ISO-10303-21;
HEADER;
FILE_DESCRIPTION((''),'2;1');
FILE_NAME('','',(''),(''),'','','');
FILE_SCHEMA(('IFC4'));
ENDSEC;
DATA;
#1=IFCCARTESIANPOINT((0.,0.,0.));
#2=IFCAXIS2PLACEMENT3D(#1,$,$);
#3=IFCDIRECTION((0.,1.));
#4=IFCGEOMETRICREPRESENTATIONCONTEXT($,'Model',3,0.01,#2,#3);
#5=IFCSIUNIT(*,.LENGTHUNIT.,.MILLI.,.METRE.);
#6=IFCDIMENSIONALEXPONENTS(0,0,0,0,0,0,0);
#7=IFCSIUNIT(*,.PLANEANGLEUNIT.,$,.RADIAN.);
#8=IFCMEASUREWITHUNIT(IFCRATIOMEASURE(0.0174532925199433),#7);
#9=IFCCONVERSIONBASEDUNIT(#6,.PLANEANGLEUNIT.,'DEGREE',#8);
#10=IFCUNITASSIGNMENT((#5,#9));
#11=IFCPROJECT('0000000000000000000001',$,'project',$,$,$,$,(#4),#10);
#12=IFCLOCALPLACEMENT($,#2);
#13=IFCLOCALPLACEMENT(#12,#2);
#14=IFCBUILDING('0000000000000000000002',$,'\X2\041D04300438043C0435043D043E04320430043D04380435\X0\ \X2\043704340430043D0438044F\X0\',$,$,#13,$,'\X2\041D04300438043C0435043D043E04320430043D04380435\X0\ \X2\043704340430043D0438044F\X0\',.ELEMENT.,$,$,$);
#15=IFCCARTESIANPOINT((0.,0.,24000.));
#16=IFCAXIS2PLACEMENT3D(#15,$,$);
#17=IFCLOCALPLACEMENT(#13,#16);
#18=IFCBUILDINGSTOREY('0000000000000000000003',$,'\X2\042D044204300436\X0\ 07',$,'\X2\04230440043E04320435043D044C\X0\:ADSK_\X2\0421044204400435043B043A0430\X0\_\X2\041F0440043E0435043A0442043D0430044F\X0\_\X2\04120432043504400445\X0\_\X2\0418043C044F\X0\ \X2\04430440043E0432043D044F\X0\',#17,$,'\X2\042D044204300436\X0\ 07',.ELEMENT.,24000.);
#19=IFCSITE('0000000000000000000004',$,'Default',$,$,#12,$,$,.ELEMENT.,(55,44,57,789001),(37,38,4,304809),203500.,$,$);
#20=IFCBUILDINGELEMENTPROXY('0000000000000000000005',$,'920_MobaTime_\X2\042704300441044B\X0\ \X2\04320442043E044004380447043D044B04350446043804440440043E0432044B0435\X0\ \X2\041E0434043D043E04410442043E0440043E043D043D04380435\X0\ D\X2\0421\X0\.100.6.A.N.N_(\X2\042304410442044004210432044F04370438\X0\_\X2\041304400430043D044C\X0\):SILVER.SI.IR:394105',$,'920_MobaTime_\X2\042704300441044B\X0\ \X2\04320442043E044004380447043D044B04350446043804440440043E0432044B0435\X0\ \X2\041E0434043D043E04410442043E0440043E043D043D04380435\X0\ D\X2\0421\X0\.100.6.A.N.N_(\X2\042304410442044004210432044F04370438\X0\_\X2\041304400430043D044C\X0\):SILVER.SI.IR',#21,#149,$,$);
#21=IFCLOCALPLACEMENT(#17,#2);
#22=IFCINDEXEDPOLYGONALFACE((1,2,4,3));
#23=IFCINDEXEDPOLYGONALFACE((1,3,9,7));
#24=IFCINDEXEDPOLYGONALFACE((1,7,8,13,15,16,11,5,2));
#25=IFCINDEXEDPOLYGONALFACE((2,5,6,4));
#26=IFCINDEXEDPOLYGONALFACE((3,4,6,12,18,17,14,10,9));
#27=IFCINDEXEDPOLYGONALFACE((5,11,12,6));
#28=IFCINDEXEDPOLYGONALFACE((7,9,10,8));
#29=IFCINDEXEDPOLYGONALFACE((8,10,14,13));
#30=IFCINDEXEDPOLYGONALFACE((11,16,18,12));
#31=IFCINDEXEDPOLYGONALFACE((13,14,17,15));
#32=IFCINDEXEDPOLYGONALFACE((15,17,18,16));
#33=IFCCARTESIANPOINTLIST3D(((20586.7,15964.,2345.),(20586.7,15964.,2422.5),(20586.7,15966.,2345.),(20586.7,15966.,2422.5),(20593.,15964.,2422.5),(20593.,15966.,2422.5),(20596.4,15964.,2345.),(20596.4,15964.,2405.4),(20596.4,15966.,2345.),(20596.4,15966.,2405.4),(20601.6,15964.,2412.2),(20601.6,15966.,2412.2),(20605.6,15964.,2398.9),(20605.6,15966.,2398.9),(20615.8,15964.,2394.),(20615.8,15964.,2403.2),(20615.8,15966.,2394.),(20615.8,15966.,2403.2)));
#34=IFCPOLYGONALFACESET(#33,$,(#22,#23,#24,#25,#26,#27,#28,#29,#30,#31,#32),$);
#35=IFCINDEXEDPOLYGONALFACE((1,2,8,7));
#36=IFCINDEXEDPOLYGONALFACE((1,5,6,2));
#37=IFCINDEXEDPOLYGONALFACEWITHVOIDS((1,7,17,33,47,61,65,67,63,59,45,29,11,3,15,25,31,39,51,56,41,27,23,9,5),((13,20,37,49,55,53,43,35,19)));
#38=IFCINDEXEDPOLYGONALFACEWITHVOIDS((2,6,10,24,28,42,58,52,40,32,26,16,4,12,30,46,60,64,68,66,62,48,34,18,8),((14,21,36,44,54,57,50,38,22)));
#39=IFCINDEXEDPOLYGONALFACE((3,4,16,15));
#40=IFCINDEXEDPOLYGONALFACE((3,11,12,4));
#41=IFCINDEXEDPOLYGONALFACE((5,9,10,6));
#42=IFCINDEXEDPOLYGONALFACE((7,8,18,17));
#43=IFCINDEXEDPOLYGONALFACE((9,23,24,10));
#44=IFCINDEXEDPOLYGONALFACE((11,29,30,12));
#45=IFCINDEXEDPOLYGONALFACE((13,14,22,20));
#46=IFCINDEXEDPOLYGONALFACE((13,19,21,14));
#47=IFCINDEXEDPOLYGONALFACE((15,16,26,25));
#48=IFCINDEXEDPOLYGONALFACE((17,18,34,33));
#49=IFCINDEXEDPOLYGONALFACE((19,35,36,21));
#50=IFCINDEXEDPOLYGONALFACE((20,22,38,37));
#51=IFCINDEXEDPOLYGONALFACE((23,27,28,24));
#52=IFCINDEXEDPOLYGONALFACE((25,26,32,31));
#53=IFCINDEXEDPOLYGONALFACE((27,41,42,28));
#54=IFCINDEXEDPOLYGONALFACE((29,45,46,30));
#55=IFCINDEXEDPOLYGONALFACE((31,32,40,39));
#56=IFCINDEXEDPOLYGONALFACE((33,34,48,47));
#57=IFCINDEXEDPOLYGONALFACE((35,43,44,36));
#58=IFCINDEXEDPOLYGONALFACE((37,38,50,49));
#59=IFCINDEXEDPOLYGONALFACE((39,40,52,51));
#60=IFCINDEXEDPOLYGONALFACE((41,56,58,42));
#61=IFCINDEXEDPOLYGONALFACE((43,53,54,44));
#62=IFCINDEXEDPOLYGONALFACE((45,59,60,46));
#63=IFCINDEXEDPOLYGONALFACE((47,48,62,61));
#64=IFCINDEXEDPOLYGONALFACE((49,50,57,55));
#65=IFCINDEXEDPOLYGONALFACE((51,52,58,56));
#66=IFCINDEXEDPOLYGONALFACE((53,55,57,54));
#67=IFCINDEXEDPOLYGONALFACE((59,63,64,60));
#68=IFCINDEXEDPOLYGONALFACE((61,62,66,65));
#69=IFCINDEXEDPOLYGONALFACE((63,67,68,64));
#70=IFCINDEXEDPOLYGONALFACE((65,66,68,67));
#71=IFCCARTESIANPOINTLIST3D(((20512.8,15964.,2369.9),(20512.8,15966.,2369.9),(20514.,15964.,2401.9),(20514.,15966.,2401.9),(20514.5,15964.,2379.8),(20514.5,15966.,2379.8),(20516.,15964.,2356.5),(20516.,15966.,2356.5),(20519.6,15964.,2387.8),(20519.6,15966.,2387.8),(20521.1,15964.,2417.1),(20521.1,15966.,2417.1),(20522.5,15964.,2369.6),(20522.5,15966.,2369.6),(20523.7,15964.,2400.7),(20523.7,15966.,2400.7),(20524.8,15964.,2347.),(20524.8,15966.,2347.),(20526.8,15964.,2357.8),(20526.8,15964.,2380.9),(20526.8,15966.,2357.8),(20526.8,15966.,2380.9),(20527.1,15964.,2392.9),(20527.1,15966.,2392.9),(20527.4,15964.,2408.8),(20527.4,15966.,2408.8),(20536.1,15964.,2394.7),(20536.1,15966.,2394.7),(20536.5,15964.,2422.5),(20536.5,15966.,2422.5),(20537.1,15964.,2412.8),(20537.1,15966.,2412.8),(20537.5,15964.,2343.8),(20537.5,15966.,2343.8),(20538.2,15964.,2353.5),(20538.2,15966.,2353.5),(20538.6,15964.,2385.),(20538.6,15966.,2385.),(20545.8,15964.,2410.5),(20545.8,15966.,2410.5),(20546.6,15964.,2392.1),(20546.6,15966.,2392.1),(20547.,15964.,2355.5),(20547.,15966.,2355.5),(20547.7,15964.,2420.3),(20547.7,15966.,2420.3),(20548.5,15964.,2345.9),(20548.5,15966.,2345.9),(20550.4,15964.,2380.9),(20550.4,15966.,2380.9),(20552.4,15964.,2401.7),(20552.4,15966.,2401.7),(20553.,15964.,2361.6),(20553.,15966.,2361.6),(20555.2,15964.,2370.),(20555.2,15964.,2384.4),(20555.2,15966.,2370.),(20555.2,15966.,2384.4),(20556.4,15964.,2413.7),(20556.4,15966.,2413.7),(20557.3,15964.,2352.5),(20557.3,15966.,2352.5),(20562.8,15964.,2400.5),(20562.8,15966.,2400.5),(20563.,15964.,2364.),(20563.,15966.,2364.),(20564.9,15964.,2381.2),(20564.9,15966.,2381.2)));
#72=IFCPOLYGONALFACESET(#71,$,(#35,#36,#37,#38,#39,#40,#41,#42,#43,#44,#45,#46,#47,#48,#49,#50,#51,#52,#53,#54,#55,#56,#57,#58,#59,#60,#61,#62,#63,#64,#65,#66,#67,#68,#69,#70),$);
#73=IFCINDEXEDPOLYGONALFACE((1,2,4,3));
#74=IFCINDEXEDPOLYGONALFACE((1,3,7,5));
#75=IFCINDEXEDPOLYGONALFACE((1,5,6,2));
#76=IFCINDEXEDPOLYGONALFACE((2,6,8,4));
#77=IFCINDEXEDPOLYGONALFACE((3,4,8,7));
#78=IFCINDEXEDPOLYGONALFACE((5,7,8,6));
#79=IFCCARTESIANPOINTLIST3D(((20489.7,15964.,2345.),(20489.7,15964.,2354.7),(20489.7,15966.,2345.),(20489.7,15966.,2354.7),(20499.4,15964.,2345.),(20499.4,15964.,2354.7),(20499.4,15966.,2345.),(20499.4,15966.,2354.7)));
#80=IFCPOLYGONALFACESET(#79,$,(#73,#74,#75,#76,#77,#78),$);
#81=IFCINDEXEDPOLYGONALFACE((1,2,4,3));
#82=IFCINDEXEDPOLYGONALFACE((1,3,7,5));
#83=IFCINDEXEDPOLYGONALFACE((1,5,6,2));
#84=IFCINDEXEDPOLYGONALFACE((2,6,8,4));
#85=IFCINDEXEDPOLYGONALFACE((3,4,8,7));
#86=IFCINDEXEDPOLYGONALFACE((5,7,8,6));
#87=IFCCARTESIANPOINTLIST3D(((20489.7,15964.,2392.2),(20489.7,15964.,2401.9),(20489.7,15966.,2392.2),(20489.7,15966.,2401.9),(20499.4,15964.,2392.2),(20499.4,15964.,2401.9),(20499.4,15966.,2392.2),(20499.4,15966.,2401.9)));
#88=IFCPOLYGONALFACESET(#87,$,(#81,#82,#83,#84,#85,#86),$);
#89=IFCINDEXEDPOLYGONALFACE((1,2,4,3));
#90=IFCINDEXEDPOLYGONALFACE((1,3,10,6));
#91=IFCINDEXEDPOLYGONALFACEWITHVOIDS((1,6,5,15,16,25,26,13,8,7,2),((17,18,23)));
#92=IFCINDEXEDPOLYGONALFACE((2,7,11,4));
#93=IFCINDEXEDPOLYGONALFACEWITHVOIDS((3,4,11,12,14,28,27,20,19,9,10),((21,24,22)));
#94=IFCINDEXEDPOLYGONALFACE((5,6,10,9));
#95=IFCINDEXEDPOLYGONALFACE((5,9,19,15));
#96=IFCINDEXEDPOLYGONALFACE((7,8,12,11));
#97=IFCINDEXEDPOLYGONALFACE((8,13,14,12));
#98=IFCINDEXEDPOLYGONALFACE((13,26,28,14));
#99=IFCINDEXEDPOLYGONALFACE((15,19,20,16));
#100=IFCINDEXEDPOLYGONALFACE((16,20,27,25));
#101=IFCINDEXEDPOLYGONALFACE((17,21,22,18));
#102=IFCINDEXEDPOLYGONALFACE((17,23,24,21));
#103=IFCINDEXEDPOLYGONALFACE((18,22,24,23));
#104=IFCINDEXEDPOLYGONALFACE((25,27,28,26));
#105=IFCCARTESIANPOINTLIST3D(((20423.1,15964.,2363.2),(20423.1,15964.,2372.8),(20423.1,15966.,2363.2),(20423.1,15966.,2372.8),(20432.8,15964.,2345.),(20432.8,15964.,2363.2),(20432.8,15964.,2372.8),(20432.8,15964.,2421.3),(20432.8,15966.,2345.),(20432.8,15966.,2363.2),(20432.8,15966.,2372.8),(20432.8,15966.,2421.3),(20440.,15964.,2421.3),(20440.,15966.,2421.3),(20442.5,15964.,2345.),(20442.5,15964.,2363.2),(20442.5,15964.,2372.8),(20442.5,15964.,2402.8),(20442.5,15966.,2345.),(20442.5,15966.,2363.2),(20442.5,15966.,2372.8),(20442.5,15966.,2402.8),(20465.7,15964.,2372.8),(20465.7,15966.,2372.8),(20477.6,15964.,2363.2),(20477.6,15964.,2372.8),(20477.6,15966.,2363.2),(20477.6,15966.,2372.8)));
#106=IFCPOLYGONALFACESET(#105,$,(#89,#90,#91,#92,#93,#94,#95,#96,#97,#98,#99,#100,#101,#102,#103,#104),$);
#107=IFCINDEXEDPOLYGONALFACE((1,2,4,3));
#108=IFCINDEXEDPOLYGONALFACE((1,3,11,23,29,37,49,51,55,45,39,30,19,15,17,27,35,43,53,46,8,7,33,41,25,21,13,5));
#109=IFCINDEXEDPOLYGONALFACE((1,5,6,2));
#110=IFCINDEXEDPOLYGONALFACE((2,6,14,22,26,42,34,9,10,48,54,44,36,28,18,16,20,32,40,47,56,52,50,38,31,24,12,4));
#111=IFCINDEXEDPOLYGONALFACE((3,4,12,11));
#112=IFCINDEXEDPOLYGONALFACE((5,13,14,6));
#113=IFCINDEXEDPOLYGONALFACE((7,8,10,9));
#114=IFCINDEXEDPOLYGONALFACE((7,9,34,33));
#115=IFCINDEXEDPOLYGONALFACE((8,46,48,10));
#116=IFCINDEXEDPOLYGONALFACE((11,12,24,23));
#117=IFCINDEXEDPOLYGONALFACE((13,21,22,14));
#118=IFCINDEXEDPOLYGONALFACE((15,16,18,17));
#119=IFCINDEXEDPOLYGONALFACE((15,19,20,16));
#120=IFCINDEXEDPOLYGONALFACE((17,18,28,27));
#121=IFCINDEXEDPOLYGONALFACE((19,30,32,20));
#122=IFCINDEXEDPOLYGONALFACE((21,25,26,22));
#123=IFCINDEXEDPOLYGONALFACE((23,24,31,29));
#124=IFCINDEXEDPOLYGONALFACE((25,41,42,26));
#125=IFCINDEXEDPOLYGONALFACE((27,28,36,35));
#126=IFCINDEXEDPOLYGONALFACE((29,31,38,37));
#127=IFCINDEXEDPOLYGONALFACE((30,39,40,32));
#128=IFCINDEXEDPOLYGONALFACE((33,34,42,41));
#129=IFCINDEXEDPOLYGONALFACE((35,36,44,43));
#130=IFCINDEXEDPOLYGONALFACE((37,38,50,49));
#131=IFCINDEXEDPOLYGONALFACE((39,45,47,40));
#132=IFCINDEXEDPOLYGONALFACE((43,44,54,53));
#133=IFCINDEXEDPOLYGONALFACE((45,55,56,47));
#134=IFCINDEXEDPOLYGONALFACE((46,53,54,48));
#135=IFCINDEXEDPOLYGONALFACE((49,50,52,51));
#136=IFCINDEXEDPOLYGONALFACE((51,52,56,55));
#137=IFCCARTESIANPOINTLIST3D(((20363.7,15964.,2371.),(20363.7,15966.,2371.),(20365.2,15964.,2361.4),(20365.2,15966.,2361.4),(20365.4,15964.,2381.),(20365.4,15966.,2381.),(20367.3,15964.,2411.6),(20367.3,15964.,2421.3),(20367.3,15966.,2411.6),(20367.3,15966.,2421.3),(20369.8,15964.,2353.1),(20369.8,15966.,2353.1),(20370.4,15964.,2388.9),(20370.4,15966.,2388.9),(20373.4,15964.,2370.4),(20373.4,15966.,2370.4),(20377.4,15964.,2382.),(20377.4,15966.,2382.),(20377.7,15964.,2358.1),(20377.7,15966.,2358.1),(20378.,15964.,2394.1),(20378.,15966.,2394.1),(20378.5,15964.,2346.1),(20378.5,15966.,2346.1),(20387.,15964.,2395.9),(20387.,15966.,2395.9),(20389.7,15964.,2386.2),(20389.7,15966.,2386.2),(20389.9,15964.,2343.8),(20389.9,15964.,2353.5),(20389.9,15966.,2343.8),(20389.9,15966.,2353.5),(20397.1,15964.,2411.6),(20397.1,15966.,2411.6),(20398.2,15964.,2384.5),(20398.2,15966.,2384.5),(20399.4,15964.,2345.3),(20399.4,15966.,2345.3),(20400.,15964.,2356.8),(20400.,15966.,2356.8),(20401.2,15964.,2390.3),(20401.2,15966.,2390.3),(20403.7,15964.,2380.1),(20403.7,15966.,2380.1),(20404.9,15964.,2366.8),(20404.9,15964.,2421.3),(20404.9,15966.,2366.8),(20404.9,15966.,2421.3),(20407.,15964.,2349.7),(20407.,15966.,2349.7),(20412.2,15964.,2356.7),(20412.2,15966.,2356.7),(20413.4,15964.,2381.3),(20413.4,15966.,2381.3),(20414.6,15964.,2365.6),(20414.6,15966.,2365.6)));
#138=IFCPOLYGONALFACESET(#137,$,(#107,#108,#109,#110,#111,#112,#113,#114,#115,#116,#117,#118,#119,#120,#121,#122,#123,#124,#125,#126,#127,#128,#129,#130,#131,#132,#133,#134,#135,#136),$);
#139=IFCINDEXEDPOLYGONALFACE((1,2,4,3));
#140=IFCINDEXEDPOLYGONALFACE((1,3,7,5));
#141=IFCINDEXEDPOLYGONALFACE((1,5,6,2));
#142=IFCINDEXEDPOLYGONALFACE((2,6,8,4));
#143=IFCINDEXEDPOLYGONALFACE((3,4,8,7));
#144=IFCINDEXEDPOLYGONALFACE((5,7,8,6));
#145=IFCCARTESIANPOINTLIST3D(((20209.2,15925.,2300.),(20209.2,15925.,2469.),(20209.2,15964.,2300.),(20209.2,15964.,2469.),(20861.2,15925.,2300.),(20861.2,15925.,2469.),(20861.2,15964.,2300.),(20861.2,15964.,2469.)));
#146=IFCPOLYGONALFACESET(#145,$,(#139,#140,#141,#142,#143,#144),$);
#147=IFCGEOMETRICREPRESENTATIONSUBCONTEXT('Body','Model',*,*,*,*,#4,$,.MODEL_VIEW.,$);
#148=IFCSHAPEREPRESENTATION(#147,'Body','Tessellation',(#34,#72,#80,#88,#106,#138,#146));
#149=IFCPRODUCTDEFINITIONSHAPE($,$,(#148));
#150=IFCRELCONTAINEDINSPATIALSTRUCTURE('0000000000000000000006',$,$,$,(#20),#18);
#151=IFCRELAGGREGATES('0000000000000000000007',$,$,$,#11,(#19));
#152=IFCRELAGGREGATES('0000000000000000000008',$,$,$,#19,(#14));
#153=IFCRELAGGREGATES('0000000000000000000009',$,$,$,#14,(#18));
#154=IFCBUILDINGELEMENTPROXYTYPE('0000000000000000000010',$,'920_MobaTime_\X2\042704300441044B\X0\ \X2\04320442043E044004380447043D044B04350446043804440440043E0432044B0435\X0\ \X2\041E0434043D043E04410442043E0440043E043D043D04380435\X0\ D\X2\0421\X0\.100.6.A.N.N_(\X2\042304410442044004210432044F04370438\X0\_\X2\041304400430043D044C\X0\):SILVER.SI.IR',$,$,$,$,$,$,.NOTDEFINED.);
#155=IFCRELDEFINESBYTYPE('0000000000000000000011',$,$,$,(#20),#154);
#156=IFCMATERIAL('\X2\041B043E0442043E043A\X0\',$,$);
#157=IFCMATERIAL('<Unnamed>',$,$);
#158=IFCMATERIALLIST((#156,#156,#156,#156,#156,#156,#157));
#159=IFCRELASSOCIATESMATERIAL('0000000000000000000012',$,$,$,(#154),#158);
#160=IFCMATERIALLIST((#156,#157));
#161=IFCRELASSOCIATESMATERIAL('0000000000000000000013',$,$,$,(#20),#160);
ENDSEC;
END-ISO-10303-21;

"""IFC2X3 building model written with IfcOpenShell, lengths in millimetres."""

from ifc_helpers import new_model, entity, si_unit, converted_unit, direction, frame, origin, origin_2d_with_axis, place, context, subcontext, project, spatial, polyline, rectangle, outline, extrude, source, transform, mapped, material, material_list, type_object, type_shapes, element, save


model = new_model("IFC2X3")

# Units and contexts
model_context = context("Model", 3, precision=0.01, world=origin(), true_north=direction((0.0, 1.0)))
body_context = subcontext(model_context, "Body", "Model", "MODEL_VIEW")
ifc_project = project(units=[si_unit("LENGTHUNIT", "METRE", prefix="MILLI"), converted_unit("PLANEANGLEUNIT", "DEGREE", entity("IfcRatioMeasure", 0.0174532925199433), si_unit("PLANEANGLEUNIT", "RADIAN"), dimensions=[0, 0, 0, 0, 0, 0, 0])], contexts=[model_context])

# Site, building, storey
site_placement = place(None, frame((0.0, 0.0, 0.0)))
site = spatial("IfcSite", under=ifc_project, at=site_placement, Name="Default", CompositionType="ELEMENT", RefLatitude=(55, 44, 57, 789001), RefLongitude=(37, 38, 4, 304809), RefElevation=203500.0)
building_placement = place(site_placement, origin())
building = spatial("IfcBuilding", under=site, at=building_placement, Name="Наименование здания", LongName="Наименование здания", CompositionType="ELEMENT")
storey_placement = place(building_placement, frame((0.0, 0.0, 24000.0)))
storey = spatial("IfcBuildingStorey", under=building, at=storey_placement, Name="Этаж 07", ObjectType="Уровень:ADSK_Стрелка_Проектная_Вверх_Имя уровня", LongName="Этаж 07", CompositionType="ELEMENT", Elevation=24000.0)

# Building element proxy
ifc_material_1 = material(Name="Лоток")
ifc_material_2 = material(Name="<Unnamed>")
ifc_material_list_1 = material_list([ifc_material_1, ifc_material_1, ifc_material_1, ifc_material_1, ifc_material_1, ifc_material_1, ifc_material_2])
building_element_proxy_type = type_object("IfcBuildingElementProxyType", Name="920_MobaTime_Часы вторичныецифровые Односторонние DС.100.6.A.N.N_(УстрСвязи_Грань):SILVER.SI.IR", PredefinedType="NOTDEFINED", material=ifc_material_list_1)
shared_shape = source(origin(), body_context, "Body", "SweptSolid", [
    extrude(outline(polyline([(-49.3, -13.1), (28.2, -13.1), (28.2, -6.8), (17.9, 1.8), (8.9, 16.0), (-0.3, 16.0), (4.6, 5.8), (11.1, -3.4), (-49.3, -3.4), (-49.3, -13.1)])), frame((-64.6, 9.8, 39.0), z_axis=(0.0, 0.0, 1.0), x_axis=(0.0, 1.0, 0.0)), (0.0, 0.0, 1.0), 2.0),
    extrude(outline(polyline([(2.2, -27.6), (19.0, -27.6), (30.5, -16.1), (33.3, -4.9), (31.0, 5.8), (21.8, 17.2), (5.2, 27.3), (-11.1, 33.0), (-24.0, 32.7), (-33.6, 27.6), (-40.3, 18.6), (-42.8, 5.7), (-38.0, -6.3), (-27.2, -15.0), (-17.5, -17.7), (-8.2, -16.4), (-0.3, -11.9), (5.1, -4.5), (7.3, 6.2), (4.0, 17.2), (18.5, 7.3), (23.6, -2.4), (22.0, -11.4), (14.2, -18.4), (5.3, -18.3), (2.2, -27.6)]), holes=[polyline([(-9.0, 23.3), (-1.3, 14.4), (-2.6, 2.0), (-11.4, -7.0), (-23.4, -6.1), (-32.2, 2.9), (-31.2, 15.1), (-25.6, 22.1), (-17.5, 24.9), (-9.0, 23.3)])]), frame((-2.7, 3.6, 39.0), z_axis=(0.0, 0.0, 1.0), x_axis=(-0.427649, 0.903945, 0.0)), (0.0, 0.0, 1.0), 2.0),
    extrude(rectangle(XDim=9.7, YDim=9.7, at=origin_2d_with_axis()), frame((40.6, -34.7, 39.0)), (0.0, 0.0, 1.0), 2.0),
    extrude(rectangle(XDim=9.7, YDim=9.7, at=origin_2d_with_axis()), frame((40.6, 12.6, 39.0)), (0.0, 0.0, 1.0), 2.0),
    extrude(outline(polyline([(-0.9, -28.1), (8.8, -28.1), (8.8, -9.9), (18.5, -9.9), (18.5, -0.2), (8.8, -0.2), (8.8, 48.3), (1.5, 48.3), (-36.0, -0.2), (-36.0, -9.9), (-0.9, -9.9), (-0.9, -28.1)]), holes=[polyline([(-0.9, -0.2), (-24.1, -0.2), (-0.9, 29.7), (-0.9, -0.2)])]), frame((93.6, -11.4, 39.0)), (0.0, 0.0, 1.0), 2.0),
    extrude(outline(polyline([(3.3, -28.3), (12.5, -28.3), (20.5, -25.0), (26.8, -18.8), (30.7, -10.0), (31.4, 1.6), (26.9, 11.8), (20.1, 18.4), (11.1, 22.3), (1.0, 23.3), (-7.9, 20.4), (-14.9, 14.5), (-18.9, 6.2), (-17.1, -9.0), (-36.7, 0.5), (-29.1, 29.3), (-38.5, 31.7), (-48.1, -4.6), (-11.6, -23.0), (-8.0, -14.0), (-10.8, -7.6), (-10.2, 1.1), (-3.0, 11.8), (9.2, 12.8), (20.0, 5.4), (21.3, -7.5), (15.5, -16.4), (4.6, -18.6), (3.3, -28.3)])), frame((147.1, -8.5, 39.0), z_axis=(0.0, 0.0, 1.0), x_axis=(0.256974, -0.966418, 0.0)), (0.0, 0.0, 1.0), 2.0),
    extrude(rectangle(XDim=652.0, YDim=169.0, at=origin_2d_with_axis()), frame((0.0, 0.0, 0.0), z_axis=(0.0, 0.0, 1.0), x_axis=(-1.0, 0.0, 0.0)), (0.0, 0.0, 1.0), 39.0),
])
type_shapes(building_element_proxy_type, [shared_shape])
ifc_material_list_2 = material_list([ifc_material_1, ifc_material_2])
proxy_1_placement = place(storey_placement, frame((20535.2, 15925.0, 2384.5), z_axis=(0.0, 1.0, 0.0), x_axis=(-1.0, 0.0, 0.0)))
element("IfcBuildingElementProxy", 1, at=proxy_1_placement, inside=storey, type_object=building_element_proxy_type, material=ifc_material_list_2, Name="920_MobaTime_Часы вторичныецифровые Односторонние DС.100.6.A.N.N_(УстрСвязи_Грань):SILVER.SI.IR:394105", ObjectType="920_MobaTime_Часы вторичныецифровые Односторонние DС.100.6.A.N.N_(УстрСвязи_Грань):SILVER.SI.IR", context=body_context, shape_type="MappedRepresentation", body=[
    mapped(shared_shape, transform((0.0, 0.0, 0.0), scale=1.0)),
])

save(model, "model.ifc")
